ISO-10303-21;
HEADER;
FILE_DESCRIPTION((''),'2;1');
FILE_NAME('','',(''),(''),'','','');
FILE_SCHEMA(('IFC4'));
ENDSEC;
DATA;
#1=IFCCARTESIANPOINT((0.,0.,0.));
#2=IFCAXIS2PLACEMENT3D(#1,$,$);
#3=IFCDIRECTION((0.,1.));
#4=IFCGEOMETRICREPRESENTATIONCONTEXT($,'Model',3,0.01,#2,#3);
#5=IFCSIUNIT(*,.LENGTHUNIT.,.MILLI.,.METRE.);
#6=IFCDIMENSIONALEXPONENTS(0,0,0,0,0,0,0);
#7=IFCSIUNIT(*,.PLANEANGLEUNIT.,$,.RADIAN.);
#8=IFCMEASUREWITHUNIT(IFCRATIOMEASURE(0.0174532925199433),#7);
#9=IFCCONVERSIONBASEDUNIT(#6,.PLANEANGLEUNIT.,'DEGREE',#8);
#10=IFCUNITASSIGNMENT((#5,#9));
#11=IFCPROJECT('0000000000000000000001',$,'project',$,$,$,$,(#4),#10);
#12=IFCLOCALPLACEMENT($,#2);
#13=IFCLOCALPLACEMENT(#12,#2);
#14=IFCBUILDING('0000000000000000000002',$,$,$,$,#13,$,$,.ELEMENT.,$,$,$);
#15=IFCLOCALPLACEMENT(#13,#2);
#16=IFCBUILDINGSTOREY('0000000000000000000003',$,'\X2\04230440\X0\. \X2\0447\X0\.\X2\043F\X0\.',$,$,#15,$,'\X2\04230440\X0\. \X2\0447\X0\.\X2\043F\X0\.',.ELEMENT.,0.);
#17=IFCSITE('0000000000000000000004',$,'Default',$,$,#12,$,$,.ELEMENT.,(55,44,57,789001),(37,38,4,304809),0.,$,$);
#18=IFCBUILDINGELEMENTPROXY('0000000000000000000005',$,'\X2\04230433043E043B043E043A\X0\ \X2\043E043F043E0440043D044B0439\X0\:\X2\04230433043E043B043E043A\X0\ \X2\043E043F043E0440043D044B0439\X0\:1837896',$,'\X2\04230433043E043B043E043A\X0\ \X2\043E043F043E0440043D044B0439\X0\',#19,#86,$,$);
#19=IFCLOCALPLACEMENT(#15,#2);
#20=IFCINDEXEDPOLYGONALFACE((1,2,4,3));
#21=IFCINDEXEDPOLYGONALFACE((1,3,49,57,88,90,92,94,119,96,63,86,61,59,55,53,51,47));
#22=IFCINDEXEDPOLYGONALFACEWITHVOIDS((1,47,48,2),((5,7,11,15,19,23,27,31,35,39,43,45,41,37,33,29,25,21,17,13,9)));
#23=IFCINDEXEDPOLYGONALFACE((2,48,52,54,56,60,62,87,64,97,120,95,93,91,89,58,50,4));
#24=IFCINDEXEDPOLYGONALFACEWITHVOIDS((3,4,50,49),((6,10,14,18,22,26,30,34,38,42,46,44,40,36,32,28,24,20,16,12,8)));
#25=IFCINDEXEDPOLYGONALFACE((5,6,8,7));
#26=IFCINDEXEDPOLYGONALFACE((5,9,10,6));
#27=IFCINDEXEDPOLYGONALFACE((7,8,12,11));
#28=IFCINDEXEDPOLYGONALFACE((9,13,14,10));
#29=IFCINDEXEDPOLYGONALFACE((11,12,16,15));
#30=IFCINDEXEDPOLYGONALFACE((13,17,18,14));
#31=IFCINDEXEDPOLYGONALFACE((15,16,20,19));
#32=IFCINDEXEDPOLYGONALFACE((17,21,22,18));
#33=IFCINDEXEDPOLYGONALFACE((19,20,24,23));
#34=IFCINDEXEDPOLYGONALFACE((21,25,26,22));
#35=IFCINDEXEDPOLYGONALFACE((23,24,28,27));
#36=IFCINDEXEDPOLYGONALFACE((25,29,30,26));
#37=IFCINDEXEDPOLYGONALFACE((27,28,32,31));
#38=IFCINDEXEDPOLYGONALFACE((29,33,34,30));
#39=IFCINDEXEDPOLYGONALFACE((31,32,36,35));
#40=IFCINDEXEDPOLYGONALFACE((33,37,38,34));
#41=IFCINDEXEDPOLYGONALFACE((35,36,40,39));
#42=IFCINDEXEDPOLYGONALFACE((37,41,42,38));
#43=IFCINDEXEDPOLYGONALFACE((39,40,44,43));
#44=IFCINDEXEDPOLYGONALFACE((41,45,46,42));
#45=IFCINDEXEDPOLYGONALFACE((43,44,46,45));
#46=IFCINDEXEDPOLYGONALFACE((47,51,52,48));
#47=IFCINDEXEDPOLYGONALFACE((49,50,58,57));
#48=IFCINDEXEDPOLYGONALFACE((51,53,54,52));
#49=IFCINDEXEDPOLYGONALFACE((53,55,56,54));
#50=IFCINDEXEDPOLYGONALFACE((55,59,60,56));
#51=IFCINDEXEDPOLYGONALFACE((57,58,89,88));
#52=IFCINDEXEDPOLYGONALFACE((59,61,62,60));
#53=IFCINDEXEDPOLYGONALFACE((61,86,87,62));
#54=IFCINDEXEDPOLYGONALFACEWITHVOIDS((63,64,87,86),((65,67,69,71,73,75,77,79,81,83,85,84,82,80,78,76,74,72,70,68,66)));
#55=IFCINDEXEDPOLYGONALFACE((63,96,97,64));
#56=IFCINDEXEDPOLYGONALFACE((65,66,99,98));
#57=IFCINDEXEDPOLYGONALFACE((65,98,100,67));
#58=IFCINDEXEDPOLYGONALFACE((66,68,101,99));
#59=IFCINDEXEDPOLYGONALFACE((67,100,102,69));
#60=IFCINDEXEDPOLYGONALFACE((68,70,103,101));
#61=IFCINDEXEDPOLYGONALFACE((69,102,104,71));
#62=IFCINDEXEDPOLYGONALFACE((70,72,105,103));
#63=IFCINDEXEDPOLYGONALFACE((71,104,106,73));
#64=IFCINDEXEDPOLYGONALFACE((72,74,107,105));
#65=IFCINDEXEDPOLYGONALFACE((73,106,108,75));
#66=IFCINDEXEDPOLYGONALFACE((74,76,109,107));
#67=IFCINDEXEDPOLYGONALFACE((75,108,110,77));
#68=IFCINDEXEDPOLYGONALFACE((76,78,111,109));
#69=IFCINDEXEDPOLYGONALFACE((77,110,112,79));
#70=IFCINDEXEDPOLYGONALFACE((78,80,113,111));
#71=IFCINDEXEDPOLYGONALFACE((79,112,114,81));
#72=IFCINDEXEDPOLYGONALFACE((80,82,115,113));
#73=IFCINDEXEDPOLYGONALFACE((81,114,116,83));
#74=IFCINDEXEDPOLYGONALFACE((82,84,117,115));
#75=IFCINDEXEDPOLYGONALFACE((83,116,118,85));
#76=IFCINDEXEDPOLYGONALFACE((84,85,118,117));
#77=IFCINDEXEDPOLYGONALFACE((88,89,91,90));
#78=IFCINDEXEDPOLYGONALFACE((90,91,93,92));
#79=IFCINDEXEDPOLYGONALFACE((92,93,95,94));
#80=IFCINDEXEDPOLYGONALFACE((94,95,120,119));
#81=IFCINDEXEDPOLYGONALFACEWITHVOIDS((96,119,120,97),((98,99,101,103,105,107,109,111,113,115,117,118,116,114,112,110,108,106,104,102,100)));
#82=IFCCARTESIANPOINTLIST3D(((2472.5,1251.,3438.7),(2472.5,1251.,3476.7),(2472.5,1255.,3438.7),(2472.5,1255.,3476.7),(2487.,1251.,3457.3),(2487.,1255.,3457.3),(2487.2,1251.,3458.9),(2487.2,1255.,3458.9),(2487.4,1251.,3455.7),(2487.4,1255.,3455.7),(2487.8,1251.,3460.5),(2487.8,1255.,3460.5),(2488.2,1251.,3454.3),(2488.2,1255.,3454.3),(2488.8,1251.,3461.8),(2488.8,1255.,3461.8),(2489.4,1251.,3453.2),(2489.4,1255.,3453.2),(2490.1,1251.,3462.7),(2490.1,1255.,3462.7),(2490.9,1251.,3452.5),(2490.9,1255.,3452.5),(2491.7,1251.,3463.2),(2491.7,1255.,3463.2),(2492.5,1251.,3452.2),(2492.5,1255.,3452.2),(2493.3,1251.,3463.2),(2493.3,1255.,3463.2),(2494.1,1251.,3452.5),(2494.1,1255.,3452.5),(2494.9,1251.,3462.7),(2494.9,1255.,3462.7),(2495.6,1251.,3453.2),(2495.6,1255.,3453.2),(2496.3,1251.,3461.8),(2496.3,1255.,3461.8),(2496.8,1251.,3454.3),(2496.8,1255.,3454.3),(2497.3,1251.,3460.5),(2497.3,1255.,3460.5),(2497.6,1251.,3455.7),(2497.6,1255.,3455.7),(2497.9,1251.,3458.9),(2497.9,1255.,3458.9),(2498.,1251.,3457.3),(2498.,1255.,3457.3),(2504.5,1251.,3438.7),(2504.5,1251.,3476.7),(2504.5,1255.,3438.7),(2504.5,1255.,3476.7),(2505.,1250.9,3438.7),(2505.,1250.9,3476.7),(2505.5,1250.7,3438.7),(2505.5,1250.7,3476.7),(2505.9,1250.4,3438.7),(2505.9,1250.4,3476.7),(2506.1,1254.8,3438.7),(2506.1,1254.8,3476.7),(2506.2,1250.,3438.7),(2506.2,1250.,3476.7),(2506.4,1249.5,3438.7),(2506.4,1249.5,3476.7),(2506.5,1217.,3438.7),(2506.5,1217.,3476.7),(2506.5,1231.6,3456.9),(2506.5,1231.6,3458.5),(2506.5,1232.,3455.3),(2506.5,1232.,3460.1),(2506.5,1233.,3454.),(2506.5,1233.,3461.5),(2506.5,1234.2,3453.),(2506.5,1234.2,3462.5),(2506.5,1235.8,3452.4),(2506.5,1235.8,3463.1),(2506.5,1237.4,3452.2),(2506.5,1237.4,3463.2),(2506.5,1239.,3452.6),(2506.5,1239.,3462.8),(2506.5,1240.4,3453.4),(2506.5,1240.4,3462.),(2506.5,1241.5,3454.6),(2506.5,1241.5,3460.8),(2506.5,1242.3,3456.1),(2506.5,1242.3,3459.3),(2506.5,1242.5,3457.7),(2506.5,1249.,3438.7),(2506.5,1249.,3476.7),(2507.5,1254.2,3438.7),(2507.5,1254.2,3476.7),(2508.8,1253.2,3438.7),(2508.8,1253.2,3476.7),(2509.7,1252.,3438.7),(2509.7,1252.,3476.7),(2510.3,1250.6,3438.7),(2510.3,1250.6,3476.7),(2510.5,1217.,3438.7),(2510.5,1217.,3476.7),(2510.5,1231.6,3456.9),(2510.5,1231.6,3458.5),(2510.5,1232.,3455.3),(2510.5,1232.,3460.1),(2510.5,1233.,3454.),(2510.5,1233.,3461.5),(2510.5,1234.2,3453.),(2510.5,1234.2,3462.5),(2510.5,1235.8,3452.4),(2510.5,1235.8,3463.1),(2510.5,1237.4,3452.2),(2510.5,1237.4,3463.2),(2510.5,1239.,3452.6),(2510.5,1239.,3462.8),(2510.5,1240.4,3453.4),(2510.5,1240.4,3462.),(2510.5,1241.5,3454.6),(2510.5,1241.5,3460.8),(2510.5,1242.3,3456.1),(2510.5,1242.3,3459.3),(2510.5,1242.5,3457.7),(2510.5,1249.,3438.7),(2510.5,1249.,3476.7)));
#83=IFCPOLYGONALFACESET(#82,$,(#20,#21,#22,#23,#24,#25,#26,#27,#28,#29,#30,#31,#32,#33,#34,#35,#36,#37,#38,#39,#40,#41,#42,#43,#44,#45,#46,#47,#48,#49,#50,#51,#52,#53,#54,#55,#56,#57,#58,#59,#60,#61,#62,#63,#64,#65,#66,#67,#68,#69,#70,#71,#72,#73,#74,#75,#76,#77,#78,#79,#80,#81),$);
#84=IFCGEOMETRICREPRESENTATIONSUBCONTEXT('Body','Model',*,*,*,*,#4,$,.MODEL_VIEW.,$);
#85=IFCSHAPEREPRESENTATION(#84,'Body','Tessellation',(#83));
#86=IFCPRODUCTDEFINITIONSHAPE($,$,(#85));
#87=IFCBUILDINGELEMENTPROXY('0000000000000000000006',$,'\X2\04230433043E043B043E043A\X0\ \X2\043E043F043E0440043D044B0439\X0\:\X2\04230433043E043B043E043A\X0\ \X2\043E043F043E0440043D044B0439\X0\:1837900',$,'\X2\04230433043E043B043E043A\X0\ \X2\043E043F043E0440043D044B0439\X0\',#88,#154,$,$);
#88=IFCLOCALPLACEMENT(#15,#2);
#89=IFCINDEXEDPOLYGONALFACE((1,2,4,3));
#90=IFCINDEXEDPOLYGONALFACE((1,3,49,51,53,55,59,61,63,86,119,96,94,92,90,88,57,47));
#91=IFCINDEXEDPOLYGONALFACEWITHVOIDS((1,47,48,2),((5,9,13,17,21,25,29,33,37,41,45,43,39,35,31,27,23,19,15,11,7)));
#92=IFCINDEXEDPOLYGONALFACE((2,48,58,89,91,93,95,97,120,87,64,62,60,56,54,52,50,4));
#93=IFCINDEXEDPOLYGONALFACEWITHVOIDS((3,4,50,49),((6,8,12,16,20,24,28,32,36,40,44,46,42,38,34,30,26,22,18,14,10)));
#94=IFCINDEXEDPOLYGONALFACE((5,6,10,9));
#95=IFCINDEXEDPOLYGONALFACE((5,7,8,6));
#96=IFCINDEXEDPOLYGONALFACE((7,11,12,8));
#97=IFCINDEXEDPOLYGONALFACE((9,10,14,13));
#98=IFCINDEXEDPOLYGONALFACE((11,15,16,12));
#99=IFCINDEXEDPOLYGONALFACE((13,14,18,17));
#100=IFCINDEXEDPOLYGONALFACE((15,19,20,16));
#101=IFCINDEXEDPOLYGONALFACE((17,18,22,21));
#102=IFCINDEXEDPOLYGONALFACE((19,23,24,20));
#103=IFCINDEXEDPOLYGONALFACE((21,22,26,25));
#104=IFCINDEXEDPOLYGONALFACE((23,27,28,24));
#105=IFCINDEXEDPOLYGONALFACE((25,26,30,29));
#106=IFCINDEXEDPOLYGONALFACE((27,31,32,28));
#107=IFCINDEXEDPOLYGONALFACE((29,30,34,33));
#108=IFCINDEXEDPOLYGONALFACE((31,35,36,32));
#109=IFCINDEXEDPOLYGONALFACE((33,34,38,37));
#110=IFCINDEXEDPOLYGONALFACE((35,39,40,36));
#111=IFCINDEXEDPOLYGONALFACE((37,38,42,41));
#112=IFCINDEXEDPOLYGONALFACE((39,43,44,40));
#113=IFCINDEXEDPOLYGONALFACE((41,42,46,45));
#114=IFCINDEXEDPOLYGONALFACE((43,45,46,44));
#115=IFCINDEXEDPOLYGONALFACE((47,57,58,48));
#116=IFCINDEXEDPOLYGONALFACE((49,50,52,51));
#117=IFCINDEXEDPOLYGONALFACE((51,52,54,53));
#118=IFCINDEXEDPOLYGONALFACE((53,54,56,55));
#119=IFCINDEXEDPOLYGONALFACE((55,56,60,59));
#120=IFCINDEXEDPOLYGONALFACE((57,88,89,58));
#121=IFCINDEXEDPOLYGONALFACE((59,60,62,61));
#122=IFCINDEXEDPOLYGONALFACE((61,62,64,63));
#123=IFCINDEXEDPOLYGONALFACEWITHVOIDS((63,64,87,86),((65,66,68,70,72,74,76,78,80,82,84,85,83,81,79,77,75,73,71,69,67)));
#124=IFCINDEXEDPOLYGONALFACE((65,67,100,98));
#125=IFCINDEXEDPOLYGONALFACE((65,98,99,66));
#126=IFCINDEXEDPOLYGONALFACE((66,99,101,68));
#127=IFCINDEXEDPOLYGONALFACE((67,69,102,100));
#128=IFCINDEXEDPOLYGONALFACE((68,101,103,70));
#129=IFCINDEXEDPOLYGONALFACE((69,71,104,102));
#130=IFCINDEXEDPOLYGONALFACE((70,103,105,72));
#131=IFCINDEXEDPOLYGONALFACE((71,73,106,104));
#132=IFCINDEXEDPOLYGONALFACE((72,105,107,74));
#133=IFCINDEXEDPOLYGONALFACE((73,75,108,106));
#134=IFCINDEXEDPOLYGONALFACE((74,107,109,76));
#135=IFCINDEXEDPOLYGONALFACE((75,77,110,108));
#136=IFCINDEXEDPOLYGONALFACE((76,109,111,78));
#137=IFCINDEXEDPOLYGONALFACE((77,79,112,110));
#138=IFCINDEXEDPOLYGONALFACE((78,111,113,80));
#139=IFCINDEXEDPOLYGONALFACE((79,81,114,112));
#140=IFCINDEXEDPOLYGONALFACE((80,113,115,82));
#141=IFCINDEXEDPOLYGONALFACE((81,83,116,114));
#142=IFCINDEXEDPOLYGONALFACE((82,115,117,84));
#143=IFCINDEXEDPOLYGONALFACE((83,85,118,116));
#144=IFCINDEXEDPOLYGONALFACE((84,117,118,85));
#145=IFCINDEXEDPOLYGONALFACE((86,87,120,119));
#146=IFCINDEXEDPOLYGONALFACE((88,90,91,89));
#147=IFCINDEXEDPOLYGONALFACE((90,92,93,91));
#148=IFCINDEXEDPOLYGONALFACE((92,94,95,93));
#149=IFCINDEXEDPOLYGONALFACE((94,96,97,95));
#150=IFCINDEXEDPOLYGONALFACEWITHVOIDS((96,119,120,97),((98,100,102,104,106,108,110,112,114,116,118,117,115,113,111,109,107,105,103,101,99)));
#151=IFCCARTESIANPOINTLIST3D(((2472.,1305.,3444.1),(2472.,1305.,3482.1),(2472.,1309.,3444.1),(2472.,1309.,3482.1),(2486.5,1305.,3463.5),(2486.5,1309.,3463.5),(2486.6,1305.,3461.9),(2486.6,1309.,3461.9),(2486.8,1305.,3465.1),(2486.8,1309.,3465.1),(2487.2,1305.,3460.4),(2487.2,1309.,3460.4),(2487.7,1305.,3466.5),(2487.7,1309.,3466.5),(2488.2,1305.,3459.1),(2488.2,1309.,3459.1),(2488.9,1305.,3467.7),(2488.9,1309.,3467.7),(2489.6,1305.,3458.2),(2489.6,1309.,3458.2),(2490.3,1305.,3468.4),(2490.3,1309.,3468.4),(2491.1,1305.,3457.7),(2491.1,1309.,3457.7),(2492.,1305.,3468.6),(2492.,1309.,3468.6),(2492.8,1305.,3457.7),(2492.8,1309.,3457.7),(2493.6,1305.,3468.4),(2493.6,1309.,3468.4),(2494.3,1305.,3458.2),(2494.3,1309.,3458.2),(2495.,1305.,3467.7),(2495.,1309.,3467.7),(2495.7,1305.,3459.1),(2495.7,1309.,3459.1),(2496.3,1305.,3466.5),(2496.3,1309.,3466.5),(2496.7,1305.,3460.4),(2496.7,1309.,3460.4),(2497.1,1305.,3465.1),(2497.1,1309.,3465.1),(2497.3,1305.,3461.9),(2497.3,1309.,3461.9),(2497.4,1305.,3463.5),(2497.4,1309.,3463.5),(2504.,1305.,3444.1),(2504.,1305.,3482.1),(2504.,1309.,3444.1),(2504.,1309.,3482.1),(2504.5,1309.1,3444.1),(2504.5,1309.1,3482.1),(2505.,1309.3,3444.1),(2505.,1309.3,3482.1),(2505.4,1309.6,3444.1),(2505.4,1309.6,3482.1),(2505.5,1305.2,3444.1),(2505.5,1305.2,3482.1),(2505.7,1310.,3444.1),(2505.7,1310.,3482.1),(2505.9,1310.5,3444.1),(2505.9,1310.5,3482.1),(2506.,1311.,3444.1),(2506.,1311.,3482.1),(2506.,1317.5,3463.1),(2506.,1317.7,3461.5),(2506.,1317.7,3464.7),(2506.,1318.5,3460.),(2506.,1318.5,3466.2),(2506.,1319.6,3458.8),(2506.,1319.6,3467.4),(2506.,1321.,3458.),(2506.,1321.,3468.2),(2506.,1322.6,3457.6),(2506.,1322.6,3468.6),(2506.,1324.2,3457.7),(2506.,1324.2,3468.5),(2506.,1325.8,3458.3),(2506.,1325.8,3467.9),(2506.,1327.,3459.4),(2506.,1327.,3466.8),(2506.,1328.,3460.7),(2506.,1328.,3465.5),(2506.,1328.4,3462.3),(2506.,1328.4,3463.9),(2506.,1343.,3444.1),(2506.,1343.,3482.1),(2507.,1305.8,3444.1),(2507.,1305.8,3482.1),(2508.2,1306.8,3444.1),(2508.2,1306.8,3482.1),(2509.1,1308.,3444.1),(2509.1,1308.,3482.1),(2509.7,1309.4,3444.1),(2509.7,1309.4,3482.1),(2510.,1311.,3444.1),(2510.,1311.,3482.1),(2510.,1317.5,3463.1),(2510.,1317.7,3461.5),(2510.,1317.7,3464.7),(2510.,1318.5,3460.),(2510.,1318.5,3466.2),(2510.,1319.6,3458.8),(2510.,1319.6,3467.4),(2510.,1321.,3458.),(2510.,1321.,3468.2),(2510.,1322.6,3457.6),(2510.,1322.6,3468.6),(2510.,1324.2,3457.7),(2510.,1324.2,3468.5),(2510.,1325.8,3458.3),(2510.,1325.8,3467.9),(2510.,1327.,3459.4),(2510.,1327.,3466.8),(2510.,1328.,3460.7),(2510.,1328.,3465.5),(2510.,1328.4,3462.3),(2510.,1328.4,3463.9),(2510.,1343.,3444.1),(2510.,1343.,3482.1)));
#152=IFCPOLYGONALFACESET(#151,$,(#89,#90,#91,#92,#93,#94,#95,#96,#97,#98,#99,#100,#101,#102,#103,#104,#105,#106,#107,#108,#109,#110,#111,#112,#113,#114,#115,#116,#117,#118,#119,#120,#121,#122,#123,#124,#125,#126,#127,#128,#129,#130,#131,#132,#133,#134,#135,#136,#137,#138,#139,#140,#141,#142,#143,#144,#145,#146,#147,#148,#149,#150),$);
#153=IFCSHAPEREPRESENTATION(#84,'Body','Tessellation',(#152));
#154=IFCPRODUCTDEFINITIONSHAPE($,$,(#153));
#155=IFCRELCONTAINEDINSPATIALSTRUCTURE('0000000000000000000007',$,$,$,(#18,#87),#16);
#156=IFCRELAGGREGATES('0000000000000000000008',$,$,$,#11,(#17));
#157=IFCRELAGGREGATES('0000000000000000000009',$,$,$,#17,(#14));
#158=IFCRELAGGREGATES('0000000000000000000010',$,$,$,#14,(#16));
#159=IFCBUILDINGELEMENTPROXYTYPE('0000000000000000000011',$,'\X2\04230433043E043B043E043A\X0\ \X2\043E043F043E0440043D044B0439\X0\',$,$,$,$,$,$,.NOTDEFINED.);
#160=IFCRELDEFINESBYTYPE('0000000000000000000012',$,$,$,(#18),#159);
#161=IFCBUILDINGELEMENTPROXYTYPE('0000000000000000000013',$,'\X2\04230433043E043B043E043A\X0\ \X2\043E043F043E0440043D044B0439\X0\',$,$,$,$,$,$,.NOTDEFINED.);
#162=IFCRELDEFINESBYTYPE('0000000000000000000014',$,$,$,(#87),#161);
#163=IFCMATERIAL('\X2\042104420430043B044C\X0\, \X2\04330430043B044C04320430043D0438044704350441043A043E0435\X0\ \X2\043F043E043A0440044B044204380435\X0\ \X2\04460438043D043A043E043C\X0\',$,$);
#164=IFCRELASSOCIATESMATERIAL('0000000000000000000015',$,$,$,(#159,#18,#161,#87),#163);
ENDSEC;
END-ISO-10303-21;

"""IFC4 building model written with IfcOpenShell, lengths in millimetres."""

from ifc_helpers import new_model, entity, si_unit, converted_unit, direction, frame, frame_2d, origin, place, context, subcontext, project, spatial, polyline, circle_curve, parameter, trimmed, segment, composite_curve, circle, outline, extrude, source, transform, mapped, material, type_object, type_shapes, element, save


model = new_model("IFC4")

# Units and contexts
model_context = context("Model", 3, precision=0.01, world=origin(), true_north=direction((0.0, 1.0)))
body_context = subcontext(model_context, "Body", "Model", "MODEL_VIEW")
ifc_project = project(units=[si_unit("LENGTHUNIT", "METRE", prefix="MILLI"), converted_unit("PLANEANGLEUNIT", "DEGREE", entity("IfcRatioMeasure", 0.0174532925199433), si_unit("PLANEANGLEUNIT", "RADIAN"), dimensions=[0, 0, 0, 0, 0, 0, 0])], contexts=[model_context])

# Site, building, storey
site_placement = place(None, origin())
site = spatial("IfcSite", under=ifc_project, at=site_placement, Name="Default", CompositionType="ELEMENT", RefLatitude=(55, 44, 57, 789001), RefLongitude=(37, 38, 4, 304809), RefElevation=0.0)
building_placement = place(site_placement, origin())
building = spatial("IfcBuilding", under=site, at=building_placement, CompositionType="ELEMENT")
storey_placement = place(building_placement, origin())
storey = spatial("IfcBuildingStorey", under=building, at=storey_placement, Name="Ур. ч.п.", LongName="Ур. ч.п.", CompositionType="ELEMENT", Elevation=0.0)

# Building element proxies, openings
ifc_material = material(Name="Сталь, гальваническое покрытие цинком")
building_element_proxy_type_1 = type_object("IfcBuildingElementProxyType", Name="Уголок опорный", material=ifc_material)
shared_shape_1 = source(origin(), body_context, "Body", "SweptSolid", [
    extrude(outline(composite_curve([segment(polyline([(-6.0, -12.0), (26.0, -12.0)]), True, "CONTINUOUS"), segment(polyline([(26.0, -12.0), (26.0, -8.0)]), True, "CONTINUOUS"), segment(polyline([(26.0, -8.0), (-6.0, -8.0)]), True, "CONTINUOUS"), segment(trimmed(circle_curve(frame_2d((-6.0, -6.0), x_axis=(0.0, -1.0)), 2.0), [parameter(270.0)], [parameter(0.0)], True, "PARAMETER"), False, "CONTINUOUS"), segment(polyline([(-8.0, -6.0), (-8.0, 26.0)]), True, "CONTINUOUS"), segment(polyline([(-8.0, 26.0), (-12.0, 26.0)]), True, "CONTINUOUS"), segment(polyline([(-12.0, 26.0), (-12.0, -6.0)]), True, "CONTINUOUS"), segment(trimmed(circle_curve(frame_2d((-6.0, -6.0), x_axis=(0.0, -1.0)), 6.0), [parameter(270.0)], [parameter(360.0)], True, "PARAMETER"), True, "CONTINUOUS")], self_intersect=False)), frame((12.0, -19.0, 12.0), z_axis=(0.0, 1.0, 0.0), x_axis=(0.0, 0.0, 1.0)), (0.0, 0.0, 1.0), 38.0),
])
type_shapes(building_element_proxy_type_1, [shared_shape_1])
proxy_1_placement = place(storey_placement, frame((2510.5, 1255.0, 3457.7), z_axis=(0.0, -1.0, 0.0), x_axis=(-1.0, 0.0, 0.0)))
proxy_1 = element("IfcBuildingElementProxy", 1, at=proxy_1_placement, inside=storey, type_object=building_element_proxy_type_1, material=ifc_material, Name="Уголок опорный:Уголок опорный:1837896", ObjectType="Уголок опорный", context=body_context, shape_type="MappedRepresentation", body=[
    mapped(shared_shape_1, transform((0.0, 0.0, 0.0), scale=1.0)),
])
opening_1_placement = place(storey_placement, frame((2510.5, 1255.0, 3457.7)))
element("IfcOpeningElement", 2, at=opening_1_placement, cuts=proxy_1, ObjectType="Opening", PredefinedType="OPENING", context=body_context, shape_type="SweptSolid", body=[
    extrude(circle(Radius=5.5, at=frame_2d((0.0, 0.0), x_axis=(1.0, 0.0))), frame((0.0, -18.0, 0.0), z_axis=(-1.0, 0.0, 0.0), x_axis=(0.0, 1.0, 0.0)), (0.0, 0.0, 1.0), 4.0),
])
opening_2_placement = place(storey_placement, frame((2510.5, 1255.0, 3457.7)))
element("IfcOpeningElement", 3, at=opening_2_placement, cuts=proxy_1, ObjectType="Opening", PredefinedType="OPENING", context=body_context, shape_type="SweptSolid", body=[
    extrude(circle(Radius=5.5, at=frame_2d((0.0, 0.0), x_axis=(1.0, 0.0))), frame((-18.0, 0.0, 0.0), z_axis=(0.0, -1.0, 0.0), x_axis=(0.0, 0.0, -1.0)), (0.0, 0.0, 1.0), 4.0),
])
building_element_proxy_type_2 = type_object("IfcBuildingElementProxyType", Name="Уголок опорный", material=ifc_material)
shared_shape_2 = source(origin(), body_context, "Body", "SweptSolid", [
    extrude(outline(composite_curve([segment(polyline([(-6.0, -12.0), (26.0, -12.0)]), True, "CONTINUOUS"), segment(polyline([(26.0, -12.0), (26.0, -8.0)]), True, "CONTINUOUS"), segment(polyline([(26.0, -8.0), (-6.0, -8.0)]), True, "CONTINUOUS"), segment(trimmed(circle_curve(frame_2d((-6.0, -6.0), x_axis=(0.0, -1.0)), 2.0), [parameter(270.0)], [parameter(0.0)], True, "PARAMETER"), False, "CONTINUOUS"), segment(polyline([(-8.0, -6.0), (-8.0, 26.0)]), True, "CONTINUOUS"), segment(polyline([(-8.0, 26.0), (-12.0, 26.0)]), True, "CONTINUOUS"), segment(polyline([(-12.0, 26.0), (-12.0, -6.0)]), True, "CONTINUOUS"), segment(trimmed(circle_curve(frame_2d((-6.0, -6.0), x_axis=(0.0, -1.0)), 6.0), [parameter(270.0)], [parameter(360.0)], True, "PARAMETER"), True, "CONTINUOUS")], self_intersect=False)), frame((12.0, -19.0, 12.0), z_axis=(0.0, 1.0, 0.0), x_axis=(0.0, 0.0, 1.0)), (0.0, 0.0, 1.0), 38.0),
])
type_shapes(building_element_proxy_type_2, [shared_shape_2])
proxy_2_placement = place(storey_placement, frame((2510.0, 1305.0, 3463.1), z_axis=(0.0, 1.0, 0.0), x_axis=(-1.0, 0.0, 0.0)))
proxy_2 = element("IfcBuildingElementProxy", 4, at=proxy_2_placement, inside=storey, type_object=building_element_proxy_type_2, material=ifc_material, Name="Уголок опорный:Уголок опорный:1837900", ObjectType="Уголок опорный", context=body_context, shape_type="MappedRepresentation", body=[
    mapped(shared_shape_2, transform((0.0, 0.0, 0.0), scale=1.0)),
])
opening_3_placement = place(storey_placement, frame((2510.0, 1305.0, 3463.1)))
element("IfcOpeningElement", 5, at=opening_3_placement, cuts=proxy_2, ObjectType="Opening", PredefinedType="OPENING", context=body_context, shape_type="SweptSolid", body=[
    extrude(circle(Radius=5.5, at=frame_2d((0.0, 0.0), x_axis=(1.0, 0.0))), frame((-4.0, 18.0, 0.0), z_axis=(1.0, 0.0, 0.0), x_axis=(0.0, -1.0, 0.0)), (0.0, 0.0, 1.0), 4.0),
])
opening_4_placement = place(storey_placement, frame((2510.0, 1305.0, 3463.1)))
element("IfcOpeningElement", 6, at=opening_4_placement, cuts=proxy_2, ObjectType="Opening", PredefinedType="OPENING", context=body_context, shape_type="SweptSolid", body=[
    extrude(circle(Radius=5.5, at=frame_2d((0.0, 0.0), x_axis=(1.0, 0.0))), frame((-18.0, 0.0, 0.0), z_axis=(0.0, 1.0, 0.0), x_axis=(0.0, 0.0, 1.0)), (0.0, 0.0, 1.0), 4.0),
])

save(model, "model.ifc")
